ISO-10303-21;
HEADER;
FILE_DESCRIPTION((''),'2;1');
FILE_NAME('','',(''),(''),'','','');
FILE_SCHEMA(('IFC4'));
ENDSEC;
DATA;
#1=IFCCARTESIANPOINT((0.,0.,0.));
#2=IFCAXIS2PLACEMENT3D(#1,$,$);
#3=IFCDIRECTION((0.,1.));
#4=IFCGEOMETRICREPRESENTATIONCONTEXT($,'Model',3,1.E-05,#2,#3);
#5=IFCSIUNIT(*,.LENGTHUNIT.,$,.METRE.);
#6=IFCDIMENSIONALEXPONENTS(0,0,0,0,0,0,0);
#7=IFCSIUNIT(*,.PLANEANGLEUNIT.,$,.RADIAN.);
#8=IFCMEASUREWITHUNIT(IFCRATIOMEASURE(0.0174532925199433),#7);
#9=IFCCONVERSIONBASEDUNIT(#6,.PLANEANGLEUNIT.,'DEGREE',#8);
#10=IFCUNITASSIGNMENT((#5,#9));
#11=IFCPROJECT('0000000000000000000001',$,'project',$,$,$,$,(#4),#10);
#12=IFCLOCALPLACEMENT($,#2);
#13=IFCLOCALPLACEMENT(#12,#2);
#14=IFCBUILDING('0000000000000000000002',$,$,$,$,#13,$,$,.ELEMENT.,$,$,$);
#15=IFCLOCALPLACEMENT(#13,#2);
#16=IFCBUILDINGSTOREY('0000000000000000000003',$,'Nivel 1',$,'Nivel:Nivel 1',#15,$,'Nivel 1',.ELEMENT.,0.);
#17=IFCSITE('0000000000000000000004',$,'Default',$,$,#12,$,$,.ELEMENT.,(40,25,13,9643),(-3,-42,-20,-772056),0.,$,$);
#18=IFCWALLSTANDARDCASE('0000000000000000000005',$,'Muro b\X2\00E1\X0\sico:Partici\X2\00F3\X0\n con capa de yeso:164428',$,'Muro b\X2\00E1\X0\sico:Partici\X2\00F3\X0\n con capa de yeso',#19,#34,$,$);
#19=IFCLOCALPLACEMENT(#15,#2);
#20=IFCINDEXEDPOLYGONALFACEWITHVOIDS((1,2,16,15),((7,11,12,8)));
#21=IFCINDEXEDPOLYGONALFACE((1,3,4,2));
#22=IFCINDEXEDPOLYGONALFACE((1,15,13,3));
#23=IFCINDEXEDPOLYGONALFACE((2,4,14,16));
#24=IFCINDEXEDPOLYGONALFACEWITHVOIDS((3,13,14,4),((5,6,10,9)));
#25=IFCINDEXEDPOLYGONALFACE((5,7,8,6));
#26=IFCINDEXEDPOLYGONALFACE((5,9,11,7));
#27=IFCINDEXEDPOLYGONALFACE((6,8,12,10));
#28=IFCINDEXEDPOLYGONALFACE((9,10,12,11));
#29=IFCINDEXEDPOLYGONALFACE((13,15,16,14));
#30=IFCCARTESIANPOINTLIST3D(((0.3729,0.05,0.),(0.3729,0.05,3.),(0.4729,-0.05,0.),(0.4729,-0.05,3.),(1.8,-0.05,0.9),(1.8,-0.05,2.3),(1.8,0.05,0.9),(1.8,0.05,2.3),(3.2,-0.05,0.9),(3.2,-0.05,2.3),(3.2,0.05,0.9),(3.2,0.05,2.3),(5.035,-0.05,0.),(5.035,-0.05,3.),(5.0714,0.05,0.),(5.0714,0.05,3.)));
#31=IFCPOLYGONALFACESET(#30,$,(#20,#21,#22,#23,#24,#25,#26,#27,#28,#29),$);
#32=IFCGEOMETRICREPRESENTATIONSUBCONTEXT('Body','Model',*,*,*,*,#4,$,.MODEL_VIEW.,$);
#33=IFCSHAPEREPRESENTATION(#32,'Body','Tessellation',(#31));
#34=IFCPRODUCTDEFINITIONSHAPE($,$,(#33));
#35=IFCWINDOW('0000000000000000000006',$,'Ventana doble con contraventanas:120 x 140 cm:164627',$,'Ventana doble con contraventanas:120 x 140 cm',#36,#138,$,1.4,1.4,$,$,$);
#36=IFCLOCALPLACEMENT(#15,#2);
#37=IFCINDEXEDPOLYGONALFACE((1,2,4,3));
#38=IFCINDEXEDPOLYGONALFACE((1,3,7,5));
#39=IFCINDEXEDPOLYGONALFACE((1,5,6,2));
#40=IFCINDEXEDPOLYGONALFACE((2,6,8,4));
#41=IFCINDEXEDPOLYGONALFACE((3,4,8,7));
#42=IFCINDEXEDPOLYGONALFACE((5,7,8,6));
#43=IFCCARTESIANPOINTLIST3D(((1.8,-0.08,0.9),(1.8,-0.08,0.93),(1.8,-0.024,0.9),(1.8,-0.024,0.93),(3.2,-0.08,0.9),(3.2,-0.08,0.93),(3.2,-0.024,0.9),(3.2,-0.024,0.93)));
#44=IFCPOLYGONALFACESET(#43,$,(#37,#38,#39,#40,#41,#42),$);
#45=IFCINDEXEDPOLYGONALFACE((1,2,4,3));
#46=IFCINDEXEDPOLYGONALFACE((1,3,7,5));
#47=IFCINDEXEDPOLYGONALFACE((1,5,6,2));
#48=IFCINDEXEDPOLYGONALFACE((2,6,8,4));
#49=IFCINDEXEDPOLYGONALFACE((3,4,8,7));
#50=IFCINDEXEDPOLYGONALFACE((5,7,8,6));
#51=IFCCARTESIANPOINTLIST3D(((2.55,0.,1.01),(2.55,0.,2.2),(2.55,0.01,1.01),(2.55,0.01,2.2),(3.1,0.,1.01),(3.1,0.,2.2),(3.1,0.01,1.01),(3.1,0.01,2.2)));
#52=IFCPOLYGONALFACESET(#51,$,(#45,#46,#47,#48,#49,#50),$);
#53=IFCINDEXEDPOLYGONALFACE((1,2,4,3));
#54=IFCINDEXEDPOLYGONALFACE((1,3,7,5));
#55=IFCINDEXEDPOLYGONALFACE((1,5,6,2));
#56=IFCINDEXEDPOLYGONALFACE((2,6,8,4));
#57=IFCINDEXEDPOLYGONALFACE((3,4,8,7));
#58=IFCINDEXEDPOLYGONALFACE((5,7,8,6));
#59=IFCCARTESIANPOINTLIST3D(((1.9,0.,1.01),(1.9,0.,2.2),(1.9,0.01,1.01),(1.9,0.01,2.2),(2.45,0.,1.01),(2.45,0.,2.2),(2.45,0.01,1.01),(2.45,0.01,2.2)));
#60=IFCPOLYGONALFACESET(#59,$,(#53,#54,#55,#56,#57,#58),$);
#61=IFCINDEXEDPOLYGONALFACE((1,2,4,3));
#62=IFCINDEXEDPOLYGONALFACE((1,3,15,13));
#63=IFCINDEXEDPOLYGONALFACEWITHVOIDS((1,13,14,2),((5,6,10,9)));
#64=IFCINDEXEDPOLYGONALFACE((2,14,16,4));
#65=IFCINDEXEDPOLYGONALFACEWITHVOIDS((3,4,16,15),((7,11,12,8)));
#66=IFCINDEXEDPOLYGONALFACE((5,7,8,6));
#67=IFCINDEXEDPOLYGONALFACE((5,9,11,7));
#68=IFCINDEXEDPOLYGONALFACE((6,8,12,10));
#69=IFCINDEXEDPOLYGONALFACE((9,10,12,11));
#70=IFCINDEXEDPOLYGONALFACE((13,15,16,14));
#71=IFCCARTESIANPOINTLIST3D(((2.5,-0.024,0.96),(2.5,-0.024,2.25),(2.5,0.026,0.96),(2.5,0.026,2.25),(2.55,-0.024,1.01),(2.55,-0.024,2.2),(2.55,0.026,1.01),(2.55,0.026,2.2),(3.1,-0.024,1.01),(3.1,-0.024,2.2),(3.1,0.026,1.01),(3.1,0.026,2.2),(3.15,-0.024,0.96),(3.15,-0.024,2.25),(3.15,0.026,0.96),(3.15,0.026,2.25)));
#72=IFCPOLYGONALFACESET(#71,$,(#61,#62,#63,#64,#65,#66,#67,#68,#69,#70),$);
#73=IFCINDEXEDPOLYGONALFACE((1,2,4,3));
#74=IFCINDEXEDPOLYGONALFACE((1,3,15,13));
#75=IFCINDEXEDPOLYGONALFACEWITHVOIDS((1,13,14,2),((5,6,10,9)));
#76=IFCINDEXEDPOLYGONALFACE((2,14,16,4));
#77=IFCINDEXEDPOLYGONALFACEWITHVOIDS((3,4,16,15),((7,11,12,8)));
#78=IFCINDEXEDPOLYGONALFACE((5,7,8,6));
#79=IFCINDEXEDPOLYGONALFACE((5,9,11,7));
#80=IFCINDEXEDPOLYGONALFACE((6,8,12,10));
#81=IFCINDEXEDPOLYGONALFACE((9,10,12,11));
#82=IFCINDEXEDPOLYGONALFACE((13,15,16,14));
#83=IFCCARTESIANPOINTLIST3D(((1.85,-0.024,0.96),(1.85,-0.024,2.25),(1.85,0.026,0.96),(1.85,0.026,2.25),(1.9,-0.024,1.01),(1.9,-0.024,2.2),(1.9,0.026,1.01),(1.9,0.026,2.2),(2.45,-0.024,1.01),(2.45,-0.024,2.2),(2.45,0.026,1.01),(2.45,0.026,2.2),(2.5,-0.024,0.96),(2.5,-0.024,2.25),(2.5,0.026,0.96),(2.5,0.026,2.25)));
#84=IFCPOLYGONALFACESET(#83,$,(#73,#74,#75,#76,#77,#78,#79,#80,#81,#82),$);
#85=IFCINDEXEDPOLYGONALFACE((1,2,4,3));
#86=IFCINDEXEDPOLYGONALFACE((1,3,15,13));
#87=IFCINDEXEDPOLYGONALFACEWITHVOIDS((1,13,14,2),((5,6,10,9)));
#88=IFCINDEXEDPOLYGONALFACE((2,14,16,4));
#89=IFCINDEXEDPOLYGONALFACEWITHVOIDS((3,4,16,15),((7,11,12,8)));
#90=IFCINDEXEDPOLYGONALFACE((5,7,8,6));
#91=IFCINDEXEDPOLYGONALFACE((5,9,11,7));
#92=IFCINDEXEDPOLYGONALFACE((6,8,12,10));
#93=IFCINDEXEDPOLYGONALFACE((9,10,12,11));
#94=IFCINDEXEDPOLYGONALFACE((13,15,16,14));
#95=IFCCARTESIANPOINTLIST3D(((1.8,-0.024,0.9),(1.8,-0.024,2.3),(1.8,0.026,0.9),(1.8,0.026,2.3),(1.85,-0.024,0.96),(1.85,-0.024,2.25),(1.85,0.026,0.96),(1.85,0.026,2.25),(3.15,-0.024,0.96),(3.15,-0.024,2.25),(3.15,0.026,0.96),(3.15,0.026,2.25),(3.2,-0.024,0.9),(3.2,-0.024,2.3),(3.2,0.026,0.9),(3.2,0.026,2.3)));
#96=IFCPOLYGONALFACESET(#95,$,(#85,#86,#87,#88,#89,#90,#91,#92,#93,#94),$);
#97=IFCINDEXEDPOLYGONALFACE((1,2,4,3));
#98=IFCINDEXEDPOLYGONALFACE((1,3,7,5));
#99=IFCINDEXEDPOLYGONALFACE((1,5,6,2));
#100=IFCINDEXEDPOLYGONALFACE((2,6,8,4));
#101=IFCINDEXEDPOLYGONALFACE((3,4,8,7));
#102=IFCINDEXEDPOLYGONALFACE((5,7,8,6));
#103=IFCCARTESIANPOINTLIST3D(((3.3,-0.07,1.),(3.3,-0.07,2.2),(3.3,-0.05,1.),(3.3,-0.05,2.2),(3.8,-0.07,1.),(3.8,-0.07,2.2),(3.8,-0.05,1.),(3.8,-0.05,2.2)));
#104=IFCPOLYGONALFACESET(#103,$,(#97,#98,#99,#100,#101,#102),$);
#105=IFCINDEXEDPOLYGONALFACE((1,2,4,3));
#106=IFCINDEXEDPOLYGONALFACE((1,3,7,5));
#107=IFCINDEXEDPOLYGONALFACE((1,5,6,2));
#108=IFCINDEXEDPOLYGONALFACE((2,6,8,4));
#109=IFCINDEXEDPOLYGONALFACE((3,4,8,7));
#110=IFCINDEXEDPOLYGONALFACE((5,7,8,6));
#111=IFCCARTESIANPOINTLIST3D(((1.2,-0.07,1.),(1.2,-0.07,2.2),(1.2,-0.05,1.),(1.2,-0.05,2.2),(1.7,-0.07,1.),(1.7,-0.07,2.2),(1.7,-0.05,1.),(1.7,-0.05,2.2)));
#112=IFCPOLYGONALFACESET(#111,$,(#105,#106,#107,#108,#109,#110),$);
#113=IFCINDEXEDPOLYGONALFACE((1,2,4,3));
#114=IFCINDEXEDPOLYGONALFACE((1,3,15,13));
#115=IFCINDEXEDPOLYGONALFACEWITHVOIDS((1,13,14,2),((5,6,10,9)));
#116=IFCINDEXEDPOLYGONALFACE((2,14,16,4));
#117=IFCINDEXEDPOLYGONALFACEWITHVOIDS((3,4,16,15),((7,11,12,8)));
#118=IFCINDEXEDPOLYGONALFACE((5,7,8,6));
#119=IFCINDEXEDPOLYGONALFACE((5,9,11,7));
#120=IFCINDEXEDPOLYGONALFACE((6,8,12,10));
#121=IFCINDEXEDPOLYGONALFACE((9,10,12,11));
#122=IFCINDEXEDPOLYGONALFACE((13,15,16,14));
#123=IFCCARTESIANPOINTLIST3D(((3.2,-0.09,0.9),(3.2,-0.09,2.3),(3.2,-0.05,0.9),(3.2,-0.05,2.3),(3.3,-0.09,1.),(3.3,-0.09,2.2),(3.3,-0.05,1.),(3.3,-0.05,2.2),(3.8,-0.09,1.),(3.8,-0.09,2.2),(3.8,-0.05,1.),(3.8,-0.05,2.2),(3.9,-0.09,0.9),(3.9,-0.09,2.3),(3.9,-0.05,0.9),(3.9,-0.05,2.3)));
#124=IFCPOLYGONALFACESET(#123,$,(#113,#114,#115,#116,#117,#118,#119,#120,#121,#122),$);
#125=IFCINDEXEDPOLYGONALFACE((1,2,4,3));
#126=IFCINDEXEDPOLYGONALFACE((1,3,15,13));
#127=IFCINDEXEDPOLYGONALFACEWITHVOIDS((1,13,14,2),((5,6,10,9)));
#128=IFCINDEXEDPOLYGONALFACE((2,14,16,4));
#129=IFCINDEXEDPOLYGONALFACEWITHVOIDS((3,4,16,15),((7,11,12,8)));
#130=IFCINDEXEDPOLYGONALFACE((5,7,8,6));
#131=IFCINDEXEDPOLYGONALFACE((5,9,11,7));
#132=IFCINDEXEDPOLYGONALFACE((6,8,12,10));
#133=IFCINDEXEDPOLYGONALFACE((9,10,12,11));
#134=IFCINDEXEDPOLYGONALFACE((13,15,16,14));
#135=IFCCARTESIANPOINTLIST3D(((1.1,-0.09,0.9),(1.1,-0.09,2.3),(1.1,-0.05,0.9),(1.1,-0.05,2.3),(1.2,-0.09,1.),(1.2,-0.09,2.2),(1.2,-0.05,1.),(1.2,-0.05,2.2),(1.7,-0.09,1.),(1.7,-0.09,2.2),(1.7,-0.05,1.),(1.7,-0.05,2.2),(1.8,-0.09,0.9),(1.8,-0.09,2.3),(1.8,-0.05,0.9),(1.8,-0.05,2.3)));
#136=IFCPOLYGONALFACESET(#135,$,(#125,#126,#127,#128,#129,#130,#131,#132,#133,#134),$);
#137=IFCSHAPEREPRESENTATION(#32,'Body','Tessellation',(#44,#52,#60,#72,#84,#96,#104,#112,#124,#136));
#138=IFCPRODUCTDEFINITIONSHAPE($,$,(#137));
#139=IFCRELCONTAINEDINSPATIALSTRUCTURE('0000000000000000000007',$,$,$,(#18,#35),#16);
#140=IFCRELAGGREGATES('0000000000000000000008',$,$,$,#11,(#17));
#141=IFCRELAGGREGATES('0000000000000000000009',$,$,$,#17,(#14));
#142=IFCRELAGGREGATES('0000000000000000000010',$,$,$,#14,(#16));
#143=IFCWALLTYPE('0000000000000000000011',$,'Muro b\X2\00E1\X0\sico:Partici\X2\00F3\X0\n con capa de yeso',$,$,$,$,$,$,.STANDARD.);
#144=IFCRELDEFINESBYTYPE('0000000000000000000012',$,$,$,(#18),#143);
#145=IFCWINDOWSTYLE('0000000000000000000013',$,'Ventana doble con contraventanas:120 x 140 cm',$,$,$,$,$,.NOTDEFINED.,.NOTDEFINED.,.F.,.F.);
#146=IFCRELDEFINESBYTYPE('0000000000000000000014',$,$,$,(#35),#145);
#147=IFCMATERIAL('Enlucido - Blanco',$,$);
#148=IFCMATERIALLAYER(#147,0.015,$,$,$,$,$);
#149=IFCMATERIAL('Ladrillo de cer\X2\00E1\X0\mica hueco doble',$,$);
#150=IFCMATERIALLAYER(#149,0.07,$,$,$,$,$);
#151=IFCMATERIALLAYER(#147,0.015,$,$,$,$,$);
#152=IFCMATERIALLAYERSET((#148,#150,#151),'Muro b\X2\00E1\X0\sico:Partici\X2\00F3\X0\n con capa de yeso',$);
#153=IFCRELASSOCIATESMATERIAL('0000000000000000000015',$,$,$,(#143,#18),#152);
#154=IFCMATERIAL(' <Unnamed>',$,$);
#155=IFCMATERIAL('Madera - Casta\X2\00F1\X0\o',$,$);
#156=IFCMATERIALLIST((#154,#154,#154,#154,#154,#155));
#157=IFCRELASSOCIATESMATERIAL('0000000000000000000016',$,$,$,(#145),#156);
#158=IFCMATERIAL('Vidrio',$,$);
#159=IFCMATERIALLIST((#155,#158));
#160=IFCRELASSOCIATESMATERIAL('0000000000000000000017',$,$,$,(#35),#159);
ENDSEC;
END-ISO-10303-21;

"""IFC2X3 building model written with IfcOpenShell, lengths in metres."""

from ifc_helpers import new_model, entity, si_unit, converted_unit, direction, frame, frame_2d, origin, origin_2d_with_axis, place, context, subcontext, project, spatial, polyline, rectangle, outline, extrude, source, transform, mapped, material, material_list, layer, layer_set, layer_usage, type_object, type_shapes, element, fill, save


model = new_model("IFC2X3")

# Units and contexts
model_context = context("Model", 3, precision=1e-05, world=origin(), true_north=direction((0.0, 1.0)))
body_context = subcontext(model_context, "Body", "Model", "MODEL_VIEW")
ifc_project = project(units=[si_unit("LENGTHUNIT", "METRE"), converted_unit("PLANEANGLEUNIT", "DEGREE", entity("IfcRatioMeasure", 0.0174532925199433), si_unit("PLANEANGLEUNIT", "RADIAN"), dimensions=[0, 0, 0, 0, 0, 0, 0])], contexts=[model_context])

# Site, building, storey
site_placement = place(None, origin())
site = spatial("IfcSite", under=ifc_project, at=site_placement, Name="Default", CompositionType="ELEMENT", RefLatitude=(40, 25, 13, 9643), RefLongitude=(-3, -42, -20, -772056), RefElevation=0.0)
building_placement = place(site_placement, origin())
building = spatial("IfcBuilding", under=site, at=building_placement, CompositionType="ELEMENT")
storey_placement = place(building_placement, origin())
storey = spatial("IfcBuildingStorey", under=building, at=storey_placement, Name="Nivel 1", ObjectType="Nivel:Nivel 1", LongName="Nivel 1", CompositionType="ELEMENT", Elevation=0.0)

# Wall, openings, window
ifc_material_1 = material(Name="Enlucido - Blanco")
ifc_layer_1 = layer(ifc_material_1, 0.015)
ifc_material_2 = material(Name="Ladrillo de cerámica hueco doble")
ifc_layer_2 = layer(ifc_material_2, 0.07)
ifc_layer_3 = layer(ifc_material_1, 0.015)
ifc_layer_set = layer_set([ifc_layer_1, ifc_layer_2, ifc_layer_3], Name="Muro básico:Partición con capa de yeso")
ifc_layer_usage_1 = layer_usage(ifc_layer_set, "AXIS2", "NEGATIVE", 0.05)
wall_type = type_object("IfcWallType", Name="Muro básico:Partición con capa de yeso", PredefinedType="STANDARD", material=ifc_layer_set)
wall_1_placement = place(storey_placement, frame((0.3729, 0.0, 0.0)))
wall_1 = element("IfcWallStandardCase", 1, at=wall_1_placement, inside=storey, type_object=wall_type, material=ifc_layer_usage_1, Name="Muro básico:Partición con capa de yeso:164428", ObjectType="Muro básico:Partición con capa de yeso", context=body_context, shape_type="SweptSolid", body=[
    extrude(outline(polyline([(0.7228, -2.1808), (0.8292, -2.1808), (0.7928, -2.0808), (-0.7294, 2.1015), (-0.7778, 2.2344), (-0.8376, 2.1063), (0.7228, -2.1808)])), frame((2.3657, 0.0167, 0.0), z_axis=(0.0, 0.0, 1.0), x_axis=(0.34202, 0.939693, 0.0)), (0.0, 0.0, 1.0), 3.0),
])
opening_1_placement = place(storey_placement, frame((0.3729, 0.0, 0.0)))
element("IfcOpeningElement", 2, at=opening_1_placement, cuts=wall_1, ObjectType="Opening", context=body_context, shape_type="SweptSolid", body=[
    extrude(rectangle(XDim=1.4, YDim=1.4, at=frame_2d((0.0, 0.0), x_axis=(0.0, 1.0))), frame((2.1271, -0.05, 1.6), z_axis=(0.0, 1.0, 0.0), x_axis=(-1.0, 0.0, 0.0)), (0.0, 0.0, 1.0), 0.1),
])
opening_2_placement = place(wall_1_placement, frame((2.8271, 0.05, 0.9)))
opening_2 = element("IfcOpeningElement", 3, at=opening_2_placement, cuts=wall_1, ObjectType="Opening", context=body_context, shape_type="SweptSolid", body=[
    extrude(rectangle(XDim=1.4, YDim=1.4, at=frame_2d((0.7, 0.7), x_axis=(1.0, 0.0))), frame((0.0, 0.0, 0.0), z_axis=(0.0, -1.0, 0.0), x_axis=(0.0, 0.0, 1.0)), (0.0, 0.0, 1.0), 0.1),
])
ifc_material_3 = material(Name="Madera - Castaño")
ifc_material_4 = material(Name="Vidrio")
ifc_material_list_1 = material_list([ifc_material_3, ifc_material_4])
ifc_material_5 = material(Name=" <Unnamed>")
ifc_material_list_2 = material_list([ifc_material_5, ifc_material_5, ifc_material_5, ifc_material_5, ifc_material_5, ifc_material_3])
window_style_1 = type_object("IfcWindowStyle", Name="Ventana doble con contraventanas:120 x 140 cm", ConstructionType="NOTDEFINED", OperationType="NOTDEFINED", ParameterTakesPrecedence=False, Sizeable=False, material=ifc_material_list_2)
shared_shape_1 = source(origin(), body_context, "Body", "SweptSolid", [
    extrude(rectangle(XDim=1.4, YDim=0.056, at=frame_2d((0.0, 0.0), x_axis=(1.0, 0.0))), frame((0.7, 0.102, 0.0)), (0.0, 0.0, 1.0), 0.03),
    extrude(rectangle(XDim=0.01, YDim=0.55, at=origin_2d_with_axis()), frame((0.375, 0.045, 0.11), z_axis=(0.0, 0.0, 1.0), x_axis=(0.0, 1.0, 0.0)), (0.0, 0.0, 1.0), 1.19),
    extrude(rectangle(XDim=0.01, YDim=0.55, at=origin_2d_with_axis()), frame((1.025, 0.045, 0.11), z_axis=(0.0, 0.0, 1.0), x_axis=(0.0, 1.0, 0.0)), (0.0, 0.0, 1.0), 1.19),
    extrude(outline(polyline([(-0.645, -0.325), (0.645, -0.325), (0.645, 0.325), (-0.645, 0.325), (-0.645, -0.325)]), holes=[polyline([(-0.595, -0.275), (-0.595, 0.275), (0.595, 0.275), (0.595, -0.275), (-0.595, -0.275)])]), frame((0.375, 0.024, 0.705), z_axis=(0.0, 1.0, 0.0), x_axis=(0.0, 0.0, -1.0)), (0.0, 0.0, 1.0), 0.05),
    extrude(outline(polyline([(-0.325, -0.645), (0.325, -0.645), (0.325, 0.645), (-0.325, 0.645), (-0.325, -0.645)]), holes=[polyline([(-0.275, -0.595), (-0.275, 0.595), (0.275, 0.595), (0.275, -0.595), (-0.275, -0.595)])]), frame((1.025, 0.024, 0.705), z_axis=(0.0, 1.0, 0.0), x_axis=(1.0, 0.0, 0.0)), (0.0, 0.0, 1.0), 0.05),
    extrude(outline(polyline([(-0.7, -0.7), (0.7, -0.7), (0.7, 0.7), (-0.7, 0.7), (-0.7, -0.7)]), holes=[polyline([(-0.65, -0.65), (-0.65, 0.64), (0.65, 0.64), (0.65, -0.65), (-0.65, -0.65)])]), frame((0.7, 0.024, 0.7), z_axis=(0.0, 1.0, 0.0), x_axis=(1.0, 0.0, 0.0)), (0.0, 0.0, 1.0), 0.05),
    extrude(rectangle(XDim=0.02, YDim=0.5, at=origin_2d_with_axis()), frame((-0.35, 0.11, 0.1), z_axis=(0.0, 0.0, 1.0), x_axis=(0.0, 1.0, 0.0)), (0.0, 0.0, 1.0), 1.2),
    extrude(rectangle(XDim=0.02, YDim=0.5, at=frame_2d((0.0, 0.0), x_axis=(1.0, 0.0))), frame((1.75, 0.11, 0.1), z_axis=(0.0, 0.0, 1.0), x_axis=(0.0, 1.0, 0.0)), (0.0, 0.0, 1.0), 1.2),
    extrude(outline(polyline([(-0.35, -0.7), (0.35, -0.7), (0.35, 0.7), (-0.35, 0.7), (-0.35, -0.7)]), holes=[polyline([(-0.25, -0.6), (-0.25, 0.6), (0.25, 0.6), (0.25, -0.6), (-0.25, -0.6)])]), frame((-0.35, 0.1, 0.7), z_axis=(0.0, 1.0, 0.0), x_axis=(1.0, 0.0, 0.0)), (0.0, 0.0, 1.0), 0.04),
    extrude(outline(polyline([(-0.7, -0.35), (0.7, -0.35), (0.7, 0.35), (-0.7, 0.35), (-0.7, -0.35)]), holes=[polyline([(-0.6, 0.25), (0.6, 0.25), (0.6, -0.25), (-0.6, -0.25), (-0.6, 0.25)])]), frame((1.75, 0.1, 0.7), z_axis=(0.0, 1.0, 0.0), x_axis=(0.0, 0.0, -1.0)), (0.0, 0.0, 1.0), 0.04),
])
type_shapes(window_style_1, [shared_shape_1])
window_1_placement = place(opening_2_placement, frame((0.0, 0.0, 0.0), z_axis=(0.0, 0.0, 1.0), x_axis=(-1.0, 0.0, 0.0)))
window_1 = element("IfcWindow", 4, at=window_1_placement, inside=storey, type_object=window_style_1, material=ifc_material_list_1, Name="Ventana doble con contraventanas:120 x 140 cm:164627", ObjectType="Ventana doble con contraventanas:120 x 140 cm", OverallHeight=1.4, OverallWidth=1.4, context=body_context, shape_type="MappedRepresentation", body=[
    mapped(shared_shape_1, transform((0.0, 0.0, 0.0), scale=1.0)),
])
fill(opening_2, window_1)

save(model, "model.ifc")
